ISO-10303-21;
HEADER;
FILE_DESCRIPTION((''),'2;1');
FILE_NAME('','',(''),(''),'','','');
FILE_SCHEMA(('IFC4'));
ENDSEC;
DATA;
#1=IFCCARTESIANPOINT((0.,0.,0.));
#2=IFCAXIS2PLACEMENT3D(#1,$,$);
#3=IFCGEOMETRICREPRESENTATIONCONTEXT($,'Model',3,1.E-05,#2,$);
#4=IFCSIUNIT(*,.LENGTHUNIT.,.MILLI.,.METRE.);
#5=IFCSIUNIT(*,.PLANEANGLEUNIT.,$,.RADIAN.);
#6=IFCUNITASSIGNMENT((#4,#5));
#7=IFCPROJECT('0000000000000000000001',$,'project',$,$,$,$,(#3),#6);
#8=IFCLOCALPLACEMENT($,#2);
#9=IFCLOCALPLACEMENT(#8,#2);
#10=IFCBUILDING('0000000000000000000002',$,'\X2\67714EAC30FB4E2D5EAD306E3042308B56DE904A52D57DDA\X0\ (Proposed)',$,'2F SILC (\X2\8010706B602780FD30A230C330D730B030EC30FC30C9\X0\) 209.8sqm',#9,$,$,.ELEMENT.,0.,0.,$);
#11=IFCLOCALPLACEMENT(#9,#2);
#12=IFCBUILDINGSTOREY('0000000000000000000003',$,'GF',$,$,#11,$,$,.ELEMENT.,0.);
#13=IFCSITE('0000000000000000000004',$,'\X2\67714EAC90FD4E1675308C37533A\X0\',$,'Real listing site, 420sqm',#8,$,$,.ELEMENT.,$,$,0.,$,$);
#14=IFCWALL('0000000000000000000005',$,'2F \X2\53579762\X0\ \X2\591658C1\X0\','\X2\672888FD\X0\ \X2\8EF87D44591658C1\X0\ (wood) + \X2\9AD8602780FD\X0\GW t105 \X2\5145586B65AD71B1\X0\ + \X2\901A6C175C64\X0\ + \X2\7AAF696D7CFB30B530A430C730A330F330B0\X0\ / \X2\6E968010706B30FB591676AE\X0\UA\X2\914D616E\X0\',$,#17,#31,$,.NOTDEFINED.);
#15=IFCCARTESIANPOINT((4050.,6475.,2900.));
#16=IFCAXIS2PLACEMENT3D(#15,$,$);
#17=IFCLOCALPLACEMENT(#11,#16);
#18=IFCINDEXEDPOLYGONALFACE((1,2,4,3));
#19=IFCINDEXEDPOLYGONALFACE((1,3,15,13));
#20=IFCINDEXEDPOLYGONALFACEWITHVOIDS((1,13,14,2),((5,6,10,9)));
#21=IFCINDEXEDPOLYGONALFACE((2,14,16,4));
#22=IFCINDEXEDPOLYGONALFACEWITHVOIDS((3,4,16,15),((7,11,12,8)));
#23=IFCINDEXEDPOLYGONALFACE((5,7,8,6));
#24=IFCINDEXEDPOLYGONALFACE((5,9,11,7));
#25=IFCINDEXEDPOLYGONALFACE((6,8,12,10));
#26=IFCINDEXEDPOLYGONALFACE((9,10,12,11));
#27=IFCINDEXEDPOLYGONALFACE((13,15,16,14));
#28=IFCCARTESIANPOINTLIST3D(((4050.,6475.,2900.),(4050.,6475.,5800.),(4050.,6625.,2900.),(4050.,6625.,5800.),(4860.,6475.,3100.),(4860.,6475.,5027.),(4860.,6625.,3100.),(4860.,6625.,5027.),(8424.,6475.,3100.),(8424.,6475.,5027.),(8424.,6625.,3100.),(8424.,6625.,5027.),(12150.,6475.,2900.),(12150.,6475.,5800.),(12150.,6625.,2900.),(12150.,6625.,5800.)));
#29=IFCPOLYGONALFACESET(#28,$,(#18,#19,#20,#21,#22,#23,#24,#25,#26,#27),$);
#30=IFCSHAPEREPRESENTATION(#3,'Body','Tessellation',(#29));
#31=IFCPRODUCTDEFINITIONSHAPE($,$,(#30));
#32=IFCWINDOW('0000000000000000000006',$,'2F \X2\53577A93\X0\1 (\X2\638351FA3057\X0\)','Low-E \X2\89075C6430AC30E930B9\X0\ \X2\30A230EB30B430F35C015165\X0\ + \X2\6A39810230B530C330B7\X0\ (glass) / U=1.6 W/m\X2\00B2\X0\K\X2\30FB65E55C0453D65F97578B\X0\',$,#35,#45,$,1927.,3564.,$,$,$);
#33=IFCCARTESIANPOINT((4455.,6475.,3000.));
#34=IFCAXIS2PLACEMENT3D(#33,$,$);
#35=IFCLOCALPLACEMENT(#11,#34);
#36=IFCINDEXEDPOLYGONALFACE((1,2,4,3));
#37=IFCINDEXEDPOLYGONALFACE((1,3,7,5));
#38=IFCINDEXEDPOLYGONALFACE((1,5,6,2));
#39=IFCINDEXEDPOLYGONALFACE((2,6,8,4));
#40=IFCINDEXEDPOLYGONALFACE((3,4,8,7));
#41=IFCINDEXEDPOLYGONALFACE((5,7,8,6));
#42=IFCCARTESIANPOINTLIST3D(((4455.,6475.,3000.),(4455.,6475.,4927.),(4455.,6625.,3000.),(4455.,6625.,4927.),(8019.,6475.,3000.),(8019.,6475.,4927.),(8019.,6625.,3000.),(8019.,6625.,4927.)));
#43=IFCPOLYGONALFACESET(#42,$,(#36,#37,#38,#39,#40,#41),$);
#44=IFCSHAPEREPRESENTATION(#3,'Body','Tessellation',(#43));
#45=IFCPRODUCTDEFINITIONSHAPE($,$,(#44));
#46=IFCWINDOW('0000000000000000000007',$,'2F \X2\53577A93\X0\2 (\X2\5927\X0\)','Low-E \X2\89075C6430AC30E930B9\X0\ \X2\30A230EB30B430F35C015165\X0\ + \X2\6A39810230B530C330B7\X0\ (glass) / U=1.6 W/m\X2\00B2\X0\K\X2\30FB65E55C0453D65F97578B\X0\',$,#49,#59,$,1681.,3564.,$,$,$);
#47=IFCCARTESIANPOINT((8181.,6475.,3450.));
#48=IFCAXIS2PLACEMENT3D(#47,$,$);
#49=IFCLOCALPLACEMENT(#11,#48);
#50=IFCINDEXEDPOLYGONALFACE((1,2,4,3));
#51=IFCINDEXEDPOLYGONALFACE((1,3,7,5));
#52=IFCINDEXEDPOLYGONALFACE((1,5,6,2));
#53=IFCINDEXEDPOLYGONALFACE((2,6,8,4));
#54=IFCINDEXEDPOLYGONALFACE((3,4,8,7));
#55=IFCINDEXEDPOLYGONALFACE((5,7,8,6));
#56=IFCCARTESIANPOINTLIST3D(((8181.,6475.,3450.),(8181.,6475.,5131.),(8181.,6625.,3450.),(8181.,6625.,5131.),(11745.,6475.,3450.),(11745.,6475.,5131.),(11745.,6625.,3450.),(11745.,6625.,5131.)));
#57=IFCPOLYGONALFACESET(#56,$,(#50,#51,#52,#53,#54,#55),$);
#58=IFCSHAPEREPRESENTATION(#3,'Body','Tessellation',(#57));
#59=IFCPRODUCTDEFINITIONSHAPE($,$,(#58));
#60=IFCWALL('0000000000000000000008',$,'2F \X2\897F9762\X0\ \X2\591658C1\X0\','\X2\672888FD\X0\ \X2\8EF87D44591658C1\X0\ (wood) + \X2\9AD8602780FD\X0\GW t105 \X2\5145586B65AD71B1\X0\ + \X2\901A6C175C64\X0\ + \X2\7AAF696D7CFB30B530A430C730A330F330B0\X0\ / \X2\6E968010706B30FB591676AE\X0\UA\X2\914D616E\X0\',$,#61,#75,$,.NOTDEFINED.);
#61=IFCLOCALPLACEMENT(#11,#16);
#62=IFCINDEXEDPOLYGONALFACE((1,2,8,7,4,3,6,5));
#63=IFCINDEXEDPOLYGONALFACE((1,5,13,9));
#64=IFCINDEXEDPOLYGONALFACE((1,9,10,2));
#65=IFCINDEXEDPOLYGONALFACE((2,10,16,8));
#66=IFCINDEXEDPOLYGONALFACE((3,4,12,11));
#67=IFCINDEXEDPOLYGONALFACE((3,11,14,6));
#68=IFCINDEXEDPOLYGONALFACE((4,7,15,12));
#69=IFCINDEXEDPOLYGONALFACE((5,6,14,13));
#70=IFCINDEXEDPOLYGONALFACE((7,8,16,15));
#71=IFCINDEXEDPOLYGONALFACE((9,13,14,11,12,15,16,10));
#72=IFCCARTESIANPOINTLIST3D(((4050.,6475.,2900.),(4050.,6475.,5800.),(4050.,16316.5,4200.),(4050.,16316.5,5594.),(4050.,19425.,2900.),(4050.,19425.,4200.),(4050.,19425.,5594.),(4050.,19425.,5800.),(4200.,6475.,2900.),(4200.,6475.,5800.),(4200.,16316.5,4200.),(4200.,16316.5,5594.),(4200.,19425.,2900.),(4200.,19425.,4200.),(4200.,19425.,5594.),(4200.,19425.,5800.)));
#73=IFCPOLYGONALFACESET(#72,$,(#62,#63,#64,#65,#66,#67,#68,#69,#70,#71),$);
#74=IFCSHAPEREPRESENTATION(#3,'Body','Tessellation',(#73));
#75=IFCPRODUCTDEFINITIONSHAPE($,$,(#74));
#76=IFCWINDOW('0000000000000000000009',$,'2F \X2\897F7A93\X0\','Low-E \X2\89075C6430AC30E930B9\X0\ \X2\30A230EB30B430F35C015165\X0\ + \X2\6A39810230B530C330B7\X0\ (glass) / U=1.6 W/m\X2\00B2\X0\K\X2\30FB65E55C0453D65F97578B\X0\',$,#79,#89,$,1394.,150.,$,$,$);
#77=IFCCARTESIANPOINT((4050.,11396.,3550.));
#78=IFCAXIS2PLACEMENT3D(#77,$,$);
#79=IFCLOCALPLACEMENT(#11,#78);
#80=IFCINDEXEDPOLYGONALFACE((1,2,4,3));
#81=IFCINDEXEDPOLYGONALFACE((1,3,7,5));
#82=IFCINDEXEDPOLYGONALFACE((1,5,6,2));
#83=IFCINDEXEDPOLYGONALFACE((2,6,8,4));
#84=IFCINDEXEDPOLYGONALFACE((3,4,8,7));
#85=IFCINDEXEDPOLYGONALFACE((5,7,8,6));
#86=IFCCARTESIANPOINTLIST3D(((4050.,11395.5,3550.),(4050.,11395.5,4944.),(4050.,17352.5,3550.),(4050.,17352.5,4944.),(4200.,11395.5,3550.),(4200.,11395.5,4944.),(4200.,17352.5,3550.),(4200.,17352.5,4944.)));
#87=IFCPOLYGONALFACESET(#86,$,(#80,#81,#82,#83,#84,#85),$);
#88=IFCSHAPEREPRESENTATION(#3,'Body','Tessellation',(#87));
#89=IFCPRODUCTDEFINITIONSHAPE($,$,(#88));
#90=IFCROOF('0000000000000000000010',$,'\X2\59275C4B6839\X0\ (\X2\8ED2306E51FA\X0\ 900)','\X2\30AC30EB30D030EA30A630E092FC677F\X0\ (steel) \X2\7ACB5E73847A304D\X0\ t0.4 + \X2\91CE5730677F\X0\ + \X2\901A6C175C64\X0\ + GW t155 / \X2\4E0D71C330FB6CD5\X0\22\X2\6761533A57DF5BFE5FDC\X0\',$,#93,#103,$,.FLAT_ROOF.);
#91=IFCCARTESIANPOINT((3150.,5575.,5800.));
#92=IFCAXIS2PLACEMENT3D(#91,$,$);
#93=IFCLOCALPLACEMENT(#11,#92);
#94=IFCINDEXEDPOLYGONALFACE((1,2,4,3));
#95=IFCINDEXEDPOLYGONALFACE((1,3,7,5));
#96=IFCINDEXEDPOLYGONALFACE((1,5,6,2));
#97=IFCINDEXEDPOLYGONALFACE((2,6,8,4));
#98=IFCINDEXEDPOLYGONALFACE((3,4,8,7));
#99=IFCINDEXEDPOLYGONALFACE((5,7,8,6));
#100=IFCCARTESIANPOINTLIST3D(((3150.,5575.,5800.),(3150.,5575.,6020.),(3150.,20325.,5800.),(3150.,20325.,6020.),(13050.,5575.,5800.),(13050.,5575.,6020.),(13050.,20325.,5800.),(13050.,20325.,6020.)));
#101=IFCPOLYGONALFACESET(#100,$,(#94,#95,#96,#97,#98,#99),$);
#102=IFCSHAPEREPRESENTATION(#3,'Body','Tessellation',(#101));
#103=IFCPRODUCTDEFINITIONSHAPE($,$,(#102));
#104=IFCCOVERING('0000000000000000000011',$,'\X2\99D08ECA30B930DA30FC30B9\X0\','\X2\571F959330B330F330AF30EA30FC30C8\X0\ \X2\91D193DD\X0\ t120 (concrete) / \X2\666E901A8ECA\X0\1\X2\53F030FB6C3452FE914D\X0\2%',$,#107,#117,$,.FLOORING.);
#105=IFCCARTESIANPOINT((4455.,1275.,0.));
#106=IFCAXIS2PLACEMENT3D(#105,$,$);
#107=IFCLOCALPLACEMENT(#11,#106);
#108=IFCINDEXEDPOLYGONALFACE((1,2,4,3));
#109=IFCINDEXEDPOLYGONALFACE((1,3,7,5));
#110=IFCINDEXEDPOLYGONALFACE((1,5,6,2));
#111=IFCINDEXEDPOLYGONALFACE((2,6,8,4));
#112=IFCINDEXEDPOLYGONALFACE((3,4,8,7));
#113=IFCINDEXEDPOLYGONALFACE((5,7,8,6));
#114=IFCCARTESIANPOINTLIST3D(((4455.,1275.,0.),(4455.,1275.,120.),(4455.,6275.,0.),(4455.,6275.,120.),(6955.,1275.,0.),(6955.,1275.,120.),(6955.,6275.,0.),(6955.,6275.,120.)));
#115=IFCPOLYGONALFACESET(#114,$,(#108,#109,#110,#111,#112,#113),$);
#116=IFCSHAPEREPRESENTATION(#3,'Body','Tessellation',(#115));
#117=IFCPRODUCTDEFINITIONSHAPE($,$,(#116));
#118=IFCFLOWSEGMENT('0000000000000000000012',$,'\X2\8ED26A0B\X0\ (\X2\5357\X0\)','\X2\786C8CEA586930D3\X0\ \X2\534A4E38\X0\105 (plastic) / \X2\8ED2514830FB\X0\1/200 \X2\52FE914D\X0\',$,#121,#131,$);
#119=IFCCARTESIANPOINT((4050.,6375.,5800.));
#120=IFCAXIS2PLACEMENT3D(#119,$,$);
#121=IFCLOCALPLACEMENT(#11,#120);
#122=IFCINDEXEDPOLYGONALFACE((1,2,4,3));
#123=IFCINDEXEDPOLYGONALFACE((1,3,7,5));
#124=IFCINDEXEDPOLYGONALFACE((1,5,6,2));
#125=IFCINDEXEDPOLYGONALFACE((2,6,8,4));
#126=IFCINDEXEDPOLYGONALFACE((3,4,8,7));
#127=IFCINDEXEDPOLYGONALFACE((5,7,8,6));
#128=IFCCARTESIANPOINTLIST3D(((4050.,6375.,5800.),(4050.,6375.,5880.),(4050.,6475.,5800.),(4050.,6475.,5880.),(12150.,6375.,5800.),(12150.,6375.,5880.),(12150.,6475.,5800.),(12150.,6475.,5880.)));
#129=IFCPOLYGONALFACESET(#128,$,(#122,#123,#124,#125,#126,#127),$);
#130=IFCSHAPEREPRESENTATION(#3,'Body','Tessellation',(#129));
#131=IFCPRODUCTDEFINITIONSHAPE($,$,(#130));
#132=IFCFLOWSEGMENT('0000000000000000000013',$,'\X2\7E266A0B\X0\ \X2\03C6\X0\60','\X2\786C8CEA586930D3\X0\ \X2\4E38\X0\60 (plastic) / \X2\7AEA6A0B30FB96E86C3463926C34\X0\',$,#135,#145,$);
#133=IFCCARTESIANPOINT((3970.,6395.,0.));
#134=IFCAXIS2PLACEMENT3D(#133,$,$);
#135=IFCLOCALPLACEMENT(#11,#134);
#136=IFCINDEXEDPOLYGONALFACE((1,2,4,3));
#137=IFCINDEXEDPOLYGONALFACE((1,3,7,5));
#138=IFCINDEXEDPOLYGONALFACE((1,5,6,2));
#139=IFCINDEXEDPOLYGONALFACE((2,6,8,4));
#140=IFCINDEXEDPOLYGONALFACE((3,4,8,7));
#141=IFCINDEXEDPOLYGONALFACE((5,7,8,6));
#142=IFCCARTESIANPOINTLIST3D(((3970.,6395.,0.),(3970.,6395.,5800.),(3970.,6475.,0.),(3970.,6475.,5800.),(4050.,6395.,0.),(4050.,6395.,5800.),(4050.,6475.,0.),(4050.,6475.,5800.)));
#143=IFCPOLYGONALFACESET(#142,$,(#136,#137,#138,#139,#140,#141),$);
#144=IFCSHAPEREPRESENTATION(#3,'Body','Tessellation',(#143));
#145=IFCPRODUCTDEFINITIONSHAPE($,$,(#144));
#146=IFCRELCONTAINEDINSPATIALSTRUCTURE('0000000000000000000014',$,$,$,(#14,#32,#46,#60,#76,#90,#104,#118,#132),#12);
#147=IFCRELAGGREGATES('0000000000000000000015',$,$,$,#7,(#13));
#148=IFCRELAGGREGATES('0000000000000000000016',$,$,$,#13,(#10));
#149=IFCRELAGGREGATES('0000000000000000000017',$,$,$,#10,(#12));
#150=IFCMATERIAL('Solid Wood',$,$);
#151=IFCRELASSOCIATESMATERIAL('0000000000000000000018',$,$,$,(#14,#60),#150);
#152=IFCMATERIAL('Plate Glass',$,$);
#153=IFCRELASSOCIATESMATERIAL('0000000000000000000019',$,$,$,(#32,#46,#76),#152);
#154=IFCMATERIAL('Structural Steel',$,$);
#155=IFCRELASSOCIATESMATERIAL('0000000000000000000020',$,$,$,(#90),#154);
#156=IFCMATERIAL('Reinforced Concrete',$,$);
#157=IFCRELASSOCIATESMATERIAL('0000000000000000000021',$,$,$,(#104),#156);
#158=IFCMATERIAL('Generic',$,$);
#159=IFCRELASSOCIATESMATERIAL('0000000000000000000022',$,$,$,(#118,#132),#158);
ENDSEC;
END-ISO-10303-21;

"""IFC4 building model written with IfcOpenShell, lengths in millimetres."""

from ifc_helpers import new_model, si_unit, frame, frame_2d, origin, place, context, project, spatial, rectangle, extrude, material, element, fill, save


model = new_model("IFC4")

# Units and contexts
model_context = context("Model", 3, precision=1e-05, world=origin())
ifc_project = project(units=[si_unit("LENGTHUNIT", "METRE", prefix="MILLI"), si_unit("PLANEANGLEUNIT", "RADIAN")], contexts=[model_context])

# Site, building, storey
site_placement = place(None, origin())
site = spatial("IfcSite", under=ifc_project, at=site_placement, Name="東京都世田谷区", ObjectType="Real listing site, 420sqm", CompositionType="ELEMENT", RefElevation=0.0)
building_placement = place(site_placement, origin())
building = spatial("IfcBuilding", under=site, at=building_placement, Name="東京・中庭のある回遊動線 (Proposed)", ObjectType="2F SILC (耐火性能アップグレード) 209.8sqm", CompositionType="ELEMENT", ElevationOfRefHeight=0.0, ElevationOfTerrain=0.0)
storey_placement = place(building_placement, origin())
storey = spatial("IfcBuildingStorey", under=building, at=storey_placement, Name="GF", CompositionType="ELEMENT", Elevation=0.0)

# Shared definitions
ifc_material_1 = material(Name="Solid Wood")

# Shared definitions
ifc_material_2 = material(Name="Reinforced Concrete")

# Shared definitions
ifc_material_3 = material(Name="Plate Glass")

# Wall, openings, windows
wall_1_placement = place(storey_placement, frame((4050.0, 6475.0, 2900.0)))
wall_1 = element("IfcWall", 1, at=wall_1_placement, inside=storey, material=ifc_material_1, Name="2F 南面 外壁", Description="木製 軸組外壁 (wood) + 高性能GW t105 充填断熱 + 通気層 + 窯業系サイディング / 準耐火・外皮UA配慮", PredefinedType="NOTDEFINED", context=model_context, shape_type="SweptSolid", body=[
    extrude(rectangle(XDim=8100.0, YDim=150.0, at=frame_2d((4050.0, 75.0))), frame((4050.0, 6475.0, 2900.0)), (0.0, 0.0, 1.0), 2900.0),
])
opening_1_placement = place(storey_placement, frame((4455.0, 6475.0, 3000.0)))
opening_1 = element("IfcOpeningElement", 2, at=opening_1_placement, cuts=wall_1, PredefinedType="NOTDEFINED", context=model_context, shape_type="SweptSolid", body=[
    extrude(rectangle(XDim=3564.0, YDim=150.0, at=frame_2d((1782.0, 75.0))), frame((4455.0, 6475.0, 3000.0)), (0.0, 0.0, 1.0), 1927.0),
])
opening_2_placement = place(storey_placement, frame((8181.0, 6475.0, 3450.0)))
opening_2 = element("IfcOpeningElement", 3, at=opening_2_placement, cuts=wall_1, PredefinedType="NOTDEFINED", context=model_context, shape_type="SweptSolid", body=[
    extrude(rectangle(XDim=3564.0, YDim=150.0, at=frame_2d((1782.0, 75.0))), frame((8181.0, 6475.0, 3450.0)), (0.0, 0.0, 1.0), 1681.0),
])
window_1_placement = place(storey_placement, frame((4455.0, 6475.0, 3000.0)))
window_1 = element("IfcWindow", 4, at=window_1_placement, inside=storey, material=ifc_material_3, Name="2F 南窓1 (掃出し)", Description="Low-E 複層ガラス アルゴン封入 + 樹脂サッシ (glass) / U=1.6 W/m²K・日射取得型", OverallHeight=1927.0, OverallWidth=3564.0, context=model_context, shape_type="SweptSolid", body=[
    extrude(rectangle(XDim=3564.0, YDim=150.0, at=frame_2d((1782.0, 75.0))), frame((4455.0, 6475.0, 3000.0)), (0.0, 0.0, 1.0), 1927.0),
])
fill(opening_1, window_1)
window_2_placement = place(storey_placement, frame((8181.0, 6475.0, 3450.0)))
window_2 = element("IfcWindow", 5, at=window_2_placement, inside=storey, material=ifc_material_3, Name="2F 南窓2 (大)", Description="Low-E 複層ガラス アルゴン封入 + 樹脂サッシ (glass) / U=1.6 W/m²K・日射取得型", OverallHeight=1681.0, OverallWidth=3564.0, context=model_context, shape_type="SweptSolid", body=[
    extrude(rectangle(XDim=3564.0, YDim=150.0, at=frame_2d((1782.0, 75.0))), frame((8181.0, 6475.0, 3450.0)), (0.0, 0.0, 1.0), 1681.0),
])
fill(opening_2, window_2)

# Wall, opening, window
wall_2_placement = place(storey_placement, frame((4050.0, 6475.0, 2900.0)))
wall_2 = element("IfcWall", 6, at=wall_2_placement, inside=storey, material=ifc_material_1, Name="2F 西面 外壁", Description="木製 軸組外壁 (wood) + 高性能GW t105 充填断熱 + 通気層 + 窯業系サイディング / 準耐火・外皮UA配慮", PredefinedType="NOTDEFINED", context=model_context, shape_type="SweptSolid", body=[
    extrude(rectangle(XDim=150.0, YDim=12950.0, at=frame_2d((75.0, 6475.0))), frame((4050.0, 6475.0, 2900.0)), (0.0, 0.0, 1.0), 2900.0),
])
opening_3_placement = place(storey_placement, frame((4050.0, 11396.0, 3550.0)))
opening_3 = element("IfcOpeningElement", 7, at=opening_3_placement, cuts=wall_2, PredefinedType="NOTDEFINED", context=model_context, shape_type="SweptSolid", body=[
    extrude(rectangle(XDim=150.0, YDim=5957.0, at=frame_2d((75.0, 2978.0))), frame((4050.0, 11396.0, 3550.0)), (0.0, 0.0, 1.0), 1394.0),
])
window_3_placement = place(storey_placement, frame((4050.0, 11396.0, 3550.0)))
window_3 = element("IfcWindow", 8, at=window_3_placement, inside=storey, material=ifc_material_3, Name="2F 西窓", Description="Low-E 複層ガラス アルゴン封入 + 樹脂サッシ (glass) / U=1.6 W/m²K・日射取得型", OverallHeight=1394.0, OverallWidth=150.0, context=model_context, shape_type="SweptSolid", body=[
    extrude(rectangle(XDim=150.0, YDim=5957.0, at=frame_2d((75.0, 2978.0))), frame((4050.0, 11396.0, 3550.0)), (0.0, 0.0, 1.0), 1394.0),
])
fill(opening_3, window_3)

# Roof
ifc_material_4 = material(Name="Structural Steel")
roof_placement = place(storey_placement, frame((3150.0, 5575.0, 5800.0)))
element("IfcRoof", 9, at=roof_placement, inside=storey, material=ifc_material_4, Name="大屋根 (軒の出 900)", Description="ガルバリウム鋼板 (steel) 立平葺き t0.4 + 野地板 + 通気層 + GW t155 / 不燃・法22条区域対応", PredefinedType="FLAT_ROOF", context=model_context, shape_type="SweptSolid", body=[
    extrude(rectangle(XDim=9900.0, YDim=14750.0, at=frame_2d((4950.0, 7375.0))), frame((3150.0, 5575.0, 5800.0)), (0.0, 0.0, 1.0), 220.0),
])

# Covering
covering_placement = place(storey_placement, frame((4455.0, 1275.0, 0.0)))
element("IfcCovering", 10, at=covering_placement, inside=storey, material=ifc_material_2, Name="駐車スペース", Description="土間コンクリート 金鏝 t120 (concrete) / 普通車1台・水勾配2%", PredefinedType="FLOORING", context=model_context, shape_type="SweptSolid", body=[
    extrude(rectangle(XDim=2500.0, YDim=5000.0, at=frame_2d((1250.0, 2500.0))), frame((4455.0, 1275.0, 0.0)), (0.0, 0.0, 1.0), 120.0),
])

# Flow segments
ifc_material_5 = material(Name="Generic")
flow_segment_1_placement = place(storey_placement, frame((4050.0, 6375.0, 5800.0)))
element("IfcFlowSegment", 11, at=flow_segment_1_placement, inside=storey, material=ifc_material_5, Name="軒樋 (南)", Description="硬質塩ビ 半丸105 (plastic) / 軒先・1/200 勾配", context=model_context, shape_type="SweptSolid", body=[
    extrude(rectangle(XDim=8100.0, YDim=100.0, at=frame_2d((4050.0, 50.0))), frame((4050.0, 6375.0, 5800.0)), (0.0, 0.0, 1.0), 80.0),
])
flow_segment_2_placement = place(storey_placement, frame((3970.0, 6395.0, 0.0)))
element("IfcFlowSegment", 12, at=flow_segment_2_placement, inside=storey, material=ifc_material_5, Name="縦樋 φ60", Description="硬質塩ビ 丸60 (plastic) / 竪樋・雨水排水", context=model_context, shape_type="SweptSolid", body=[
    extrude(rectangle(XDim=80.0, YDim=80.0, at=frame_2d((40.0, 40.0))), frame((3970.0, 6395.0, 0.0)), (0.0, 0.0, 1.0), 5800.0),
])

save(model, "model.ifc")
